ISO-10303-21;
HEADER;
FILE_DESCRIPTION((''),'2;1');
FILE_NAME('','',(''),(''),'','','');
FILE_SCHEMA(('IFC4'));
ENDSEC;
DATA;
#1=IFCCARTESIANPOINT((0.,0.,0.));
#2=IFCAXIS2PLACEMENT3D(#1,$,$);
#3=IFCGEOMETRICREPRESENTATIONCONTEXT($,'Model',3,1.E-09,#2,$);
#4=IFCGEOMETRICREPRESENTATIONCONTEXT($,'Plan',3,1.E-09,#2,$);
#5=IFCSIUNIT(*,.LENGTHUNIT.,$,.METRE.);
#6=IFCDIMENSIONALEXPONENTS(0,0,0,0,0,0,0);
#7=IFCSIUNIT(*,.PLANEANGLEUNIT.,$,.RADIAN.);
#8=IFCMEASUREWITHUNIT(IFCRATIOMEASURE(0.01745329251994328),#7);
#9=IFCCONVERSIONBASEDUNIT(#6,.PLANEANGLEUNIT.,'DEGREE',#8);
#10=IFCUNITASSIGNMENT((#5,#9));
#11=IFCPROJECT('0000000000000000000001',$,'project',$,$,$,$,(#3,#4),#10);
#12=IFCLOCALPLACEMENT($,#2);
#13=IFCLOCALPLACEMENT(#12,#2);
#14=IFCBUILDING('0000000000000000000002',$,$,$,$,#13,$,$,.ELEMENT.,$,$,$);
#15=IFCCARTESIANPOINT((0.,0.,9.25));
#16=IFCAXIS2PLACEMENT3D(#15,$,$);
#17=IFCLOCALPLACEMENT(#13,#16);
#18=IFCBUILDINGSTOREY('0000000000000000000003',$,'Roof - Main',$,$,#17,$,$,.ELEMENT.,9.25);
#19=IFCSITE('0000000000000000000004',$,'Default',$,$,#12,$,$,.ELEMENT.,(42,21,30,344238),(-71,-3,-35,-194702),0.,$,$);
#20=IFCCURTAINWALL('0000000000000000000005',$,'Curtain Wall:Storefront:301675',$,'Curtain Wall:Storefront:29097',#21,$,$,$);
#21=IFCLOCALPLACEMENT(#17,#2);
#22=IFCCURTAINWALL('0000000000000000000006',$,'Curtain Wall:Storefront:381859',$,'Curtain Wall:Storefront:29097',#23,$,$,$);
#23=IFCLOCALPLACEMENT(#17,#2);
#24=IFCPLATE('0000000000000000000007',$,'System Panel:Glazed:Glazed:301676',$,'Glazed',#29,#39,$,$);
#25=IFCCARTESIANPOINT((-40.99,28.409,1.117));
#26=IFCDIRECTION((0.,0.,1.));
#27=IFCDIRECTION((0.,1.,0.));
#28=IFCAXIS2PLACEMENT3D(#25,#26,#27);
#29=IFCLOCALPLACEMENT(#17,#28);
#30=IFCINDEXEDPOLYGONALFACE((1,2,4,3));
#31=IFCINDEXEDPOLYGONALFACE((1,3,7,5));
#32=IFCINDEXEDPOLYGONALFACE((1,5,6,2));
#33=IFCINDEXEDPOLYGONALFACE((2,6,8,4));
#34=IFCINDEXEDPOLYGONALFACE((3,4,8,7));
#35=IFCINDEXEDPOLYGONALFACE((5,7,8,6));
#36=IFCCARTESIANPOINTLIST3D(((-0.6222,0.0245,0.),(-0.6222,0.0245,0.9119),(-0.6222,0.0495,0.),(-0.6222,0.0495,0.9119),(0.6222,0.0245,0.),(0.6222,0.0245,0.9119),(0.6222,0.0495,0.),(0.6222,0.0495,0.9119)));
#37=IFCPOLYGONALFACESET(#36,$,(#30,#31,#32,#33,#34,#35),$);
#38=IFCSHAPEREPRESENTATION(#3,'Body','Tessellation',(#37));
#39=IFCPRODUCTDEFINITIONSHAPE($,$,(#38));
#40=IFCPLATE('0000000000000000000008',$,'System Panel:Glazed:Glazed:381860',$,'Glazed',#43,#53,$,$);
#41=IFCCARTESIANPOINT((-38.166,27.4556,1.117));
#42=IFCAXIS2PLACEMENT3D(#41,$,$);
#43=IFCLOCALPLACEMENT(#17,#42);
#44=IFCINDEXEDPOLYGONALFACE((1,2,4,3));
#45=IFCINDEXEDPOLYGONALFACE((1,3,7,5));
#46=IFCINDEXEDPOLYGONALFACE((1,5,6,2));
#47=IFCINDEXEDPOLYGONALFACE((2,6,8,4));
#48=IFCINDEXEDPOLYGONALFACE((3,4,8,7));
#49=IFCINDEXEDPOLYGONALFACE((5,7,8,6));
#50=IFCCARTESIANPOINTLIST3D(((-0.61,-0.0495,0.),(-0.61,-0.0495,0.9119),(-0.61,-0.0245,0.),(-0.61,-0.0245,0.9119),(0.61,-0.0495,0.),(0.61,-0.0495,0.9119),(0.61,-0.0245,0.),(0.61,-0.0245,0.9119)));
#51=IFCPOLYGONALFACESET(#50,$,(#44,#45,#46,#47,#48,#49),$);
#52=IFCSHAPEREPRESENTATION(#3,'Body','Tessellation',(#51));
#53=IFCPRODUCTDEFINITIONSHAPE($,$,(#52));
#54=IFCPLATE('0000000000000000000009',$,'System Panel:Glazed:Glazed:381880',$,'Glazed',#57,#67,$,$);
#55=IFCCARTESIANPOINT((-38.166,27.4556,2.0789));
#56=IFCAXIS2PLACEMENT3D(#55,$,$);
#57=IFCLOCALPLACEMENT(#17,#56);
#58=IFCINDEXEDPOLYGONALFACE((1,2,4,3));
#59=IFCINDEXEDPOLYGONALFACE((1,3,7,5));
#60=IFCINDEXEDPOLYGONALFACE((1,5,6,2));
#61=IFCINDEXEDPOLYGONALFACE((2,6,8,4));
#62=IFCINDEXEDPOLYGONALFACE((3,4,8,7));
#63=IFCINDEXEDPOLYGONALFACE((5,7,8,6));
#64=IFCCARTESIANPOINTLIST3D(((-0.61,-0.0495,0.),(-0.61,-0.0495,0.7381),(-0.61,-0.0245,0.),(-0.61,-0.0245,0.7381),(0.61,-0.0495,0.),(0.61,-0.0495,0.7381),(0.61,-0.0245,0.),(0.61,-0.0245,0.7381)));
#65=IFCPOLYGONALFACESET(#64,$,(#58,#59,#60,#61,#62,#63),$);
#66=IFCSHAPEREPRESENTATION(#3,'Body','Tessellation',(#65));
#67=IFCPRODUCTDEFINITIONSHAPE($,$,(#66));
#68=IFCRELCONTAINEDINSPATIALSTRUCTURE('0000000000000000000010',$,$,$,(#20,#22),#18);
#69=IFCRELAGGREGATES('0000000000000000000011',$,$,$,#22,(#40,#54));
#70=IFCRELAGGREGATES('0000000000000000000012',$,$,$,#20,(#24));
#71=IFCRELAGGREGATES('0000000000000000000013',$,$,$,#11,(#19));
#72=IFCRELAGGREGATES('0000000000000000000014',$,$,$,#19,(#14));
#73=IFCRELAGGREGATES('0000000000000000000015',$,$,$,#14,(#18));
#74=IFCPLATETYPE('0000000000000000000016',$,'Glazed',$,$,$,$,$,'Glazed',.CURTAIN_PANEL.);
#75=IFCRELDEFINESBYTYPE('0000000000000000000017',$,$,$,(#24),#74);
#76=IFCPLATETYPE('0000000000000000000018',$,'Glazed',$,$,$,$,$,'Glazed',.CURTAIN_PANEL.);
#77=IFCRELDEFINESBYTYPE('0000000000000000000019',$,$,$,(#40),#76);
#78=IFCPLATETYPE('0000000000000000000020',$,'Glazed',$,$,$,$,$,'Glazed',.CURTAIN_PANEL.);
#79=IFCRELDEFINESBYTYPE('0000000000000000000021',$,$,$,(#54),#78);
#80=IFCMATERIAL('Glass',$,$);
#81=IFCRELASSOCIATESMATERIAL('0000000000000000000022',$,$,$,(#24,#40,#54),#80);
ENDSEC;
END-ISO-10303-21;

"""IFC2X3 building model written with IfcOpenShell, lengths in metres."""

from ifc_helpers import new_model, entity, si_unit, converted_unit, frame, origin, origin_2d_with_axis, place, context, project, spatial, rectangle, extrude, source, transform, mapped, material, type_object, type_shapes, element, aggregate, save


model = new_model("IFC2X3")

# Units and contexts
model_context = context("Model", 3, precision=1e-09, world=origin())
plan_context = context("Plan", 3, precision=1e-09, world=origin())
ifc_project = project(units=[si_unit("LENGTHUNIT", "METRE"), converted_unit("PLANEANGLEUNIT", "DEGREE", entity("IfcRatioMeasure", 0.01745329251994328), si_unit("PLANEANGLEUNIT", "RADIAN"), dimensions=[0, 0, 0, 0, 0, 0, 0])], contexts=[model_context, plan_context])

# Site, building, storey
site_placement = place(None, origin())
site = spatial("IfcSite", under=ifc_project, at=site_placement, Name="Default", CompositionType="ELEMENT", RefLatitude=(42, 21, 30, 344238), RefLongitude=(-71, -3, -35, -194702), RefElevation=0.0)
building_placement = place(site_placement, origin())
building = spatial("IfcBuilding", under=site, at=building_placement, CompositionType="ELEMENT")
storey_placement = place(building_placement, frame((0.0, 0.0, 9.25)))
storey = spatial("IfcBuildingStorey", under=building, at=storey_placement, Name="Roof - Main", CompositionType="ELEMENT", Elevation=9.25)

# Curtain walls
curtain_wall_1_placement = place(storey_placement, origin())
curtain_wall_1 = element("IfcCurtainWall", 1, at=curtain_wall_1_placement, inside=storey, Name="Curtain Wall:Storefront:301675", ObjectType="Curtain Wall:Storefront:29097")
curtain_wall_2_placement = place(storey_placement, origin())
curtain_wall_2 = element("IfcCurtainWall", 2, at=curtain_wall_2_placement, inside=storey, Name="Curtain Wall:Storefront:381859", ObjectType="Curtain Wall:Storefront:29097")

# Plates
ifc_material_1 = material(Name="Glass")
plate_type_1 = type_object("IfcPlateType", Name="Glazed", ElementType="Glazed", PredefinedType="CURTAIN_PANEL")
shared_shape_1 = source(origin(), model_context, "Body", "SweptSolid", [
    extrude(rectangle(XDim=0.025, YDim=1.2444, at=origin_2d_with_axis()), frame((0.0, 0.037, 0.0), z_axis=(0.0, 0.0, 1.0), x_axis=(0.0, 1.0, 0.0)), (0.0, 0.0, 1.0), 0.9119),
])
type_shapes(plate_type_1, [shared_shape_1])
plate_1_placement = place(storey_placement, frame((-40.99, 28.409, 1.117), z_axis=(0.0, 0.0, 1.0), x_axis=(0.0, 1.0, 0.0)))
plate_1 = element("IfcPlate", 3, at=plate_1_placement, type_object=plate_type_1, material=ifc_material_1, Name="System Panel:Glazed:Glazed:301676", ObjectType="Glazed", context=model_context, shape_type="MappedRepresentation", body=[
    mapped(shared_shape_1, transform((0.0, 0.0, 0.0), scale=1.0)),
])
plate_type_2 = type_object("IfcPlateType", Name="Glazed", ElementType="Glazed", PredefinedType="CURTAIN_PANEL")
shared_shape_2 = source(origin(), model_context, "Body", "SweptSolid", [
    extrude(rectangle(XDim=0.025, YDim=1.22, at=origin_2d_with_axis()), frame((0.0, -0.037, 0.0), z_axis=(0.0, 0.0, 1.0), x_axis=(0.0, 1.0, 0.0)), (0.0, 0.0, 1.0), 0.9119),
])
type_shapes(plate_type_2, [shared_shape_2])
plate_2_placement = place(storey_placement, frame((-38.166, 27.4556, 1.117)))
plate_2 = element("IfcPlate", 4, at=plate_2_placement, type_object=plate_type_2, material=ifc_material_1, Name="System Panel:Glazed:Glazed:381860", ObjectType="Glazed", context=model_context, shape_type="MappedRepresentation", body=[
    mapped(shared_shape_2, transform((0.0, 0.0, 0.0), scale=1.0)),
])
plate_type_3 = type_object("IfcPlateType", Name="Glazed", ElementType="Glazed", PredefinedType="CURTAIN_PANEL")
shared_shape_3 = source(origin(), model_context, "Body", "SweptSolid", [
    extrude(rectangle(XDim=0.025, YDim=1.22, at=origin_2d_with_axis()), frame((0.0, -0.037, 0.0), z_axis=(0.0, 0.0, 1.0), x_axis=(0.0, 1.0, 0.0)), (0.0, 0.0, 1.0), 0.7381),
])
type_shapes(plate_type_3, [shared_shape_3])
plate_3_placement = place(storey_placement, frame((-38.166, 27.4556, 2.0789)))
plate_3 = element("IfcPlate", 5, at=plate_3_placement, type_object=plate_type_3, material=ifc_material_1, Name="System Panel:Glazed:Glazed:381880", ObjectType="Glazed", context=model_context, shape_type="MappedRepresentation", body=[
    mapped(shared_shape_3, transform((0.0, 0.0, 0.0), scale=1.0)),
])
aggregate(curtain_wall_2, [plate_2, plate_3])
aggregate(curtain_wall_1, [plate_1])

save(model, "model.ifc")
